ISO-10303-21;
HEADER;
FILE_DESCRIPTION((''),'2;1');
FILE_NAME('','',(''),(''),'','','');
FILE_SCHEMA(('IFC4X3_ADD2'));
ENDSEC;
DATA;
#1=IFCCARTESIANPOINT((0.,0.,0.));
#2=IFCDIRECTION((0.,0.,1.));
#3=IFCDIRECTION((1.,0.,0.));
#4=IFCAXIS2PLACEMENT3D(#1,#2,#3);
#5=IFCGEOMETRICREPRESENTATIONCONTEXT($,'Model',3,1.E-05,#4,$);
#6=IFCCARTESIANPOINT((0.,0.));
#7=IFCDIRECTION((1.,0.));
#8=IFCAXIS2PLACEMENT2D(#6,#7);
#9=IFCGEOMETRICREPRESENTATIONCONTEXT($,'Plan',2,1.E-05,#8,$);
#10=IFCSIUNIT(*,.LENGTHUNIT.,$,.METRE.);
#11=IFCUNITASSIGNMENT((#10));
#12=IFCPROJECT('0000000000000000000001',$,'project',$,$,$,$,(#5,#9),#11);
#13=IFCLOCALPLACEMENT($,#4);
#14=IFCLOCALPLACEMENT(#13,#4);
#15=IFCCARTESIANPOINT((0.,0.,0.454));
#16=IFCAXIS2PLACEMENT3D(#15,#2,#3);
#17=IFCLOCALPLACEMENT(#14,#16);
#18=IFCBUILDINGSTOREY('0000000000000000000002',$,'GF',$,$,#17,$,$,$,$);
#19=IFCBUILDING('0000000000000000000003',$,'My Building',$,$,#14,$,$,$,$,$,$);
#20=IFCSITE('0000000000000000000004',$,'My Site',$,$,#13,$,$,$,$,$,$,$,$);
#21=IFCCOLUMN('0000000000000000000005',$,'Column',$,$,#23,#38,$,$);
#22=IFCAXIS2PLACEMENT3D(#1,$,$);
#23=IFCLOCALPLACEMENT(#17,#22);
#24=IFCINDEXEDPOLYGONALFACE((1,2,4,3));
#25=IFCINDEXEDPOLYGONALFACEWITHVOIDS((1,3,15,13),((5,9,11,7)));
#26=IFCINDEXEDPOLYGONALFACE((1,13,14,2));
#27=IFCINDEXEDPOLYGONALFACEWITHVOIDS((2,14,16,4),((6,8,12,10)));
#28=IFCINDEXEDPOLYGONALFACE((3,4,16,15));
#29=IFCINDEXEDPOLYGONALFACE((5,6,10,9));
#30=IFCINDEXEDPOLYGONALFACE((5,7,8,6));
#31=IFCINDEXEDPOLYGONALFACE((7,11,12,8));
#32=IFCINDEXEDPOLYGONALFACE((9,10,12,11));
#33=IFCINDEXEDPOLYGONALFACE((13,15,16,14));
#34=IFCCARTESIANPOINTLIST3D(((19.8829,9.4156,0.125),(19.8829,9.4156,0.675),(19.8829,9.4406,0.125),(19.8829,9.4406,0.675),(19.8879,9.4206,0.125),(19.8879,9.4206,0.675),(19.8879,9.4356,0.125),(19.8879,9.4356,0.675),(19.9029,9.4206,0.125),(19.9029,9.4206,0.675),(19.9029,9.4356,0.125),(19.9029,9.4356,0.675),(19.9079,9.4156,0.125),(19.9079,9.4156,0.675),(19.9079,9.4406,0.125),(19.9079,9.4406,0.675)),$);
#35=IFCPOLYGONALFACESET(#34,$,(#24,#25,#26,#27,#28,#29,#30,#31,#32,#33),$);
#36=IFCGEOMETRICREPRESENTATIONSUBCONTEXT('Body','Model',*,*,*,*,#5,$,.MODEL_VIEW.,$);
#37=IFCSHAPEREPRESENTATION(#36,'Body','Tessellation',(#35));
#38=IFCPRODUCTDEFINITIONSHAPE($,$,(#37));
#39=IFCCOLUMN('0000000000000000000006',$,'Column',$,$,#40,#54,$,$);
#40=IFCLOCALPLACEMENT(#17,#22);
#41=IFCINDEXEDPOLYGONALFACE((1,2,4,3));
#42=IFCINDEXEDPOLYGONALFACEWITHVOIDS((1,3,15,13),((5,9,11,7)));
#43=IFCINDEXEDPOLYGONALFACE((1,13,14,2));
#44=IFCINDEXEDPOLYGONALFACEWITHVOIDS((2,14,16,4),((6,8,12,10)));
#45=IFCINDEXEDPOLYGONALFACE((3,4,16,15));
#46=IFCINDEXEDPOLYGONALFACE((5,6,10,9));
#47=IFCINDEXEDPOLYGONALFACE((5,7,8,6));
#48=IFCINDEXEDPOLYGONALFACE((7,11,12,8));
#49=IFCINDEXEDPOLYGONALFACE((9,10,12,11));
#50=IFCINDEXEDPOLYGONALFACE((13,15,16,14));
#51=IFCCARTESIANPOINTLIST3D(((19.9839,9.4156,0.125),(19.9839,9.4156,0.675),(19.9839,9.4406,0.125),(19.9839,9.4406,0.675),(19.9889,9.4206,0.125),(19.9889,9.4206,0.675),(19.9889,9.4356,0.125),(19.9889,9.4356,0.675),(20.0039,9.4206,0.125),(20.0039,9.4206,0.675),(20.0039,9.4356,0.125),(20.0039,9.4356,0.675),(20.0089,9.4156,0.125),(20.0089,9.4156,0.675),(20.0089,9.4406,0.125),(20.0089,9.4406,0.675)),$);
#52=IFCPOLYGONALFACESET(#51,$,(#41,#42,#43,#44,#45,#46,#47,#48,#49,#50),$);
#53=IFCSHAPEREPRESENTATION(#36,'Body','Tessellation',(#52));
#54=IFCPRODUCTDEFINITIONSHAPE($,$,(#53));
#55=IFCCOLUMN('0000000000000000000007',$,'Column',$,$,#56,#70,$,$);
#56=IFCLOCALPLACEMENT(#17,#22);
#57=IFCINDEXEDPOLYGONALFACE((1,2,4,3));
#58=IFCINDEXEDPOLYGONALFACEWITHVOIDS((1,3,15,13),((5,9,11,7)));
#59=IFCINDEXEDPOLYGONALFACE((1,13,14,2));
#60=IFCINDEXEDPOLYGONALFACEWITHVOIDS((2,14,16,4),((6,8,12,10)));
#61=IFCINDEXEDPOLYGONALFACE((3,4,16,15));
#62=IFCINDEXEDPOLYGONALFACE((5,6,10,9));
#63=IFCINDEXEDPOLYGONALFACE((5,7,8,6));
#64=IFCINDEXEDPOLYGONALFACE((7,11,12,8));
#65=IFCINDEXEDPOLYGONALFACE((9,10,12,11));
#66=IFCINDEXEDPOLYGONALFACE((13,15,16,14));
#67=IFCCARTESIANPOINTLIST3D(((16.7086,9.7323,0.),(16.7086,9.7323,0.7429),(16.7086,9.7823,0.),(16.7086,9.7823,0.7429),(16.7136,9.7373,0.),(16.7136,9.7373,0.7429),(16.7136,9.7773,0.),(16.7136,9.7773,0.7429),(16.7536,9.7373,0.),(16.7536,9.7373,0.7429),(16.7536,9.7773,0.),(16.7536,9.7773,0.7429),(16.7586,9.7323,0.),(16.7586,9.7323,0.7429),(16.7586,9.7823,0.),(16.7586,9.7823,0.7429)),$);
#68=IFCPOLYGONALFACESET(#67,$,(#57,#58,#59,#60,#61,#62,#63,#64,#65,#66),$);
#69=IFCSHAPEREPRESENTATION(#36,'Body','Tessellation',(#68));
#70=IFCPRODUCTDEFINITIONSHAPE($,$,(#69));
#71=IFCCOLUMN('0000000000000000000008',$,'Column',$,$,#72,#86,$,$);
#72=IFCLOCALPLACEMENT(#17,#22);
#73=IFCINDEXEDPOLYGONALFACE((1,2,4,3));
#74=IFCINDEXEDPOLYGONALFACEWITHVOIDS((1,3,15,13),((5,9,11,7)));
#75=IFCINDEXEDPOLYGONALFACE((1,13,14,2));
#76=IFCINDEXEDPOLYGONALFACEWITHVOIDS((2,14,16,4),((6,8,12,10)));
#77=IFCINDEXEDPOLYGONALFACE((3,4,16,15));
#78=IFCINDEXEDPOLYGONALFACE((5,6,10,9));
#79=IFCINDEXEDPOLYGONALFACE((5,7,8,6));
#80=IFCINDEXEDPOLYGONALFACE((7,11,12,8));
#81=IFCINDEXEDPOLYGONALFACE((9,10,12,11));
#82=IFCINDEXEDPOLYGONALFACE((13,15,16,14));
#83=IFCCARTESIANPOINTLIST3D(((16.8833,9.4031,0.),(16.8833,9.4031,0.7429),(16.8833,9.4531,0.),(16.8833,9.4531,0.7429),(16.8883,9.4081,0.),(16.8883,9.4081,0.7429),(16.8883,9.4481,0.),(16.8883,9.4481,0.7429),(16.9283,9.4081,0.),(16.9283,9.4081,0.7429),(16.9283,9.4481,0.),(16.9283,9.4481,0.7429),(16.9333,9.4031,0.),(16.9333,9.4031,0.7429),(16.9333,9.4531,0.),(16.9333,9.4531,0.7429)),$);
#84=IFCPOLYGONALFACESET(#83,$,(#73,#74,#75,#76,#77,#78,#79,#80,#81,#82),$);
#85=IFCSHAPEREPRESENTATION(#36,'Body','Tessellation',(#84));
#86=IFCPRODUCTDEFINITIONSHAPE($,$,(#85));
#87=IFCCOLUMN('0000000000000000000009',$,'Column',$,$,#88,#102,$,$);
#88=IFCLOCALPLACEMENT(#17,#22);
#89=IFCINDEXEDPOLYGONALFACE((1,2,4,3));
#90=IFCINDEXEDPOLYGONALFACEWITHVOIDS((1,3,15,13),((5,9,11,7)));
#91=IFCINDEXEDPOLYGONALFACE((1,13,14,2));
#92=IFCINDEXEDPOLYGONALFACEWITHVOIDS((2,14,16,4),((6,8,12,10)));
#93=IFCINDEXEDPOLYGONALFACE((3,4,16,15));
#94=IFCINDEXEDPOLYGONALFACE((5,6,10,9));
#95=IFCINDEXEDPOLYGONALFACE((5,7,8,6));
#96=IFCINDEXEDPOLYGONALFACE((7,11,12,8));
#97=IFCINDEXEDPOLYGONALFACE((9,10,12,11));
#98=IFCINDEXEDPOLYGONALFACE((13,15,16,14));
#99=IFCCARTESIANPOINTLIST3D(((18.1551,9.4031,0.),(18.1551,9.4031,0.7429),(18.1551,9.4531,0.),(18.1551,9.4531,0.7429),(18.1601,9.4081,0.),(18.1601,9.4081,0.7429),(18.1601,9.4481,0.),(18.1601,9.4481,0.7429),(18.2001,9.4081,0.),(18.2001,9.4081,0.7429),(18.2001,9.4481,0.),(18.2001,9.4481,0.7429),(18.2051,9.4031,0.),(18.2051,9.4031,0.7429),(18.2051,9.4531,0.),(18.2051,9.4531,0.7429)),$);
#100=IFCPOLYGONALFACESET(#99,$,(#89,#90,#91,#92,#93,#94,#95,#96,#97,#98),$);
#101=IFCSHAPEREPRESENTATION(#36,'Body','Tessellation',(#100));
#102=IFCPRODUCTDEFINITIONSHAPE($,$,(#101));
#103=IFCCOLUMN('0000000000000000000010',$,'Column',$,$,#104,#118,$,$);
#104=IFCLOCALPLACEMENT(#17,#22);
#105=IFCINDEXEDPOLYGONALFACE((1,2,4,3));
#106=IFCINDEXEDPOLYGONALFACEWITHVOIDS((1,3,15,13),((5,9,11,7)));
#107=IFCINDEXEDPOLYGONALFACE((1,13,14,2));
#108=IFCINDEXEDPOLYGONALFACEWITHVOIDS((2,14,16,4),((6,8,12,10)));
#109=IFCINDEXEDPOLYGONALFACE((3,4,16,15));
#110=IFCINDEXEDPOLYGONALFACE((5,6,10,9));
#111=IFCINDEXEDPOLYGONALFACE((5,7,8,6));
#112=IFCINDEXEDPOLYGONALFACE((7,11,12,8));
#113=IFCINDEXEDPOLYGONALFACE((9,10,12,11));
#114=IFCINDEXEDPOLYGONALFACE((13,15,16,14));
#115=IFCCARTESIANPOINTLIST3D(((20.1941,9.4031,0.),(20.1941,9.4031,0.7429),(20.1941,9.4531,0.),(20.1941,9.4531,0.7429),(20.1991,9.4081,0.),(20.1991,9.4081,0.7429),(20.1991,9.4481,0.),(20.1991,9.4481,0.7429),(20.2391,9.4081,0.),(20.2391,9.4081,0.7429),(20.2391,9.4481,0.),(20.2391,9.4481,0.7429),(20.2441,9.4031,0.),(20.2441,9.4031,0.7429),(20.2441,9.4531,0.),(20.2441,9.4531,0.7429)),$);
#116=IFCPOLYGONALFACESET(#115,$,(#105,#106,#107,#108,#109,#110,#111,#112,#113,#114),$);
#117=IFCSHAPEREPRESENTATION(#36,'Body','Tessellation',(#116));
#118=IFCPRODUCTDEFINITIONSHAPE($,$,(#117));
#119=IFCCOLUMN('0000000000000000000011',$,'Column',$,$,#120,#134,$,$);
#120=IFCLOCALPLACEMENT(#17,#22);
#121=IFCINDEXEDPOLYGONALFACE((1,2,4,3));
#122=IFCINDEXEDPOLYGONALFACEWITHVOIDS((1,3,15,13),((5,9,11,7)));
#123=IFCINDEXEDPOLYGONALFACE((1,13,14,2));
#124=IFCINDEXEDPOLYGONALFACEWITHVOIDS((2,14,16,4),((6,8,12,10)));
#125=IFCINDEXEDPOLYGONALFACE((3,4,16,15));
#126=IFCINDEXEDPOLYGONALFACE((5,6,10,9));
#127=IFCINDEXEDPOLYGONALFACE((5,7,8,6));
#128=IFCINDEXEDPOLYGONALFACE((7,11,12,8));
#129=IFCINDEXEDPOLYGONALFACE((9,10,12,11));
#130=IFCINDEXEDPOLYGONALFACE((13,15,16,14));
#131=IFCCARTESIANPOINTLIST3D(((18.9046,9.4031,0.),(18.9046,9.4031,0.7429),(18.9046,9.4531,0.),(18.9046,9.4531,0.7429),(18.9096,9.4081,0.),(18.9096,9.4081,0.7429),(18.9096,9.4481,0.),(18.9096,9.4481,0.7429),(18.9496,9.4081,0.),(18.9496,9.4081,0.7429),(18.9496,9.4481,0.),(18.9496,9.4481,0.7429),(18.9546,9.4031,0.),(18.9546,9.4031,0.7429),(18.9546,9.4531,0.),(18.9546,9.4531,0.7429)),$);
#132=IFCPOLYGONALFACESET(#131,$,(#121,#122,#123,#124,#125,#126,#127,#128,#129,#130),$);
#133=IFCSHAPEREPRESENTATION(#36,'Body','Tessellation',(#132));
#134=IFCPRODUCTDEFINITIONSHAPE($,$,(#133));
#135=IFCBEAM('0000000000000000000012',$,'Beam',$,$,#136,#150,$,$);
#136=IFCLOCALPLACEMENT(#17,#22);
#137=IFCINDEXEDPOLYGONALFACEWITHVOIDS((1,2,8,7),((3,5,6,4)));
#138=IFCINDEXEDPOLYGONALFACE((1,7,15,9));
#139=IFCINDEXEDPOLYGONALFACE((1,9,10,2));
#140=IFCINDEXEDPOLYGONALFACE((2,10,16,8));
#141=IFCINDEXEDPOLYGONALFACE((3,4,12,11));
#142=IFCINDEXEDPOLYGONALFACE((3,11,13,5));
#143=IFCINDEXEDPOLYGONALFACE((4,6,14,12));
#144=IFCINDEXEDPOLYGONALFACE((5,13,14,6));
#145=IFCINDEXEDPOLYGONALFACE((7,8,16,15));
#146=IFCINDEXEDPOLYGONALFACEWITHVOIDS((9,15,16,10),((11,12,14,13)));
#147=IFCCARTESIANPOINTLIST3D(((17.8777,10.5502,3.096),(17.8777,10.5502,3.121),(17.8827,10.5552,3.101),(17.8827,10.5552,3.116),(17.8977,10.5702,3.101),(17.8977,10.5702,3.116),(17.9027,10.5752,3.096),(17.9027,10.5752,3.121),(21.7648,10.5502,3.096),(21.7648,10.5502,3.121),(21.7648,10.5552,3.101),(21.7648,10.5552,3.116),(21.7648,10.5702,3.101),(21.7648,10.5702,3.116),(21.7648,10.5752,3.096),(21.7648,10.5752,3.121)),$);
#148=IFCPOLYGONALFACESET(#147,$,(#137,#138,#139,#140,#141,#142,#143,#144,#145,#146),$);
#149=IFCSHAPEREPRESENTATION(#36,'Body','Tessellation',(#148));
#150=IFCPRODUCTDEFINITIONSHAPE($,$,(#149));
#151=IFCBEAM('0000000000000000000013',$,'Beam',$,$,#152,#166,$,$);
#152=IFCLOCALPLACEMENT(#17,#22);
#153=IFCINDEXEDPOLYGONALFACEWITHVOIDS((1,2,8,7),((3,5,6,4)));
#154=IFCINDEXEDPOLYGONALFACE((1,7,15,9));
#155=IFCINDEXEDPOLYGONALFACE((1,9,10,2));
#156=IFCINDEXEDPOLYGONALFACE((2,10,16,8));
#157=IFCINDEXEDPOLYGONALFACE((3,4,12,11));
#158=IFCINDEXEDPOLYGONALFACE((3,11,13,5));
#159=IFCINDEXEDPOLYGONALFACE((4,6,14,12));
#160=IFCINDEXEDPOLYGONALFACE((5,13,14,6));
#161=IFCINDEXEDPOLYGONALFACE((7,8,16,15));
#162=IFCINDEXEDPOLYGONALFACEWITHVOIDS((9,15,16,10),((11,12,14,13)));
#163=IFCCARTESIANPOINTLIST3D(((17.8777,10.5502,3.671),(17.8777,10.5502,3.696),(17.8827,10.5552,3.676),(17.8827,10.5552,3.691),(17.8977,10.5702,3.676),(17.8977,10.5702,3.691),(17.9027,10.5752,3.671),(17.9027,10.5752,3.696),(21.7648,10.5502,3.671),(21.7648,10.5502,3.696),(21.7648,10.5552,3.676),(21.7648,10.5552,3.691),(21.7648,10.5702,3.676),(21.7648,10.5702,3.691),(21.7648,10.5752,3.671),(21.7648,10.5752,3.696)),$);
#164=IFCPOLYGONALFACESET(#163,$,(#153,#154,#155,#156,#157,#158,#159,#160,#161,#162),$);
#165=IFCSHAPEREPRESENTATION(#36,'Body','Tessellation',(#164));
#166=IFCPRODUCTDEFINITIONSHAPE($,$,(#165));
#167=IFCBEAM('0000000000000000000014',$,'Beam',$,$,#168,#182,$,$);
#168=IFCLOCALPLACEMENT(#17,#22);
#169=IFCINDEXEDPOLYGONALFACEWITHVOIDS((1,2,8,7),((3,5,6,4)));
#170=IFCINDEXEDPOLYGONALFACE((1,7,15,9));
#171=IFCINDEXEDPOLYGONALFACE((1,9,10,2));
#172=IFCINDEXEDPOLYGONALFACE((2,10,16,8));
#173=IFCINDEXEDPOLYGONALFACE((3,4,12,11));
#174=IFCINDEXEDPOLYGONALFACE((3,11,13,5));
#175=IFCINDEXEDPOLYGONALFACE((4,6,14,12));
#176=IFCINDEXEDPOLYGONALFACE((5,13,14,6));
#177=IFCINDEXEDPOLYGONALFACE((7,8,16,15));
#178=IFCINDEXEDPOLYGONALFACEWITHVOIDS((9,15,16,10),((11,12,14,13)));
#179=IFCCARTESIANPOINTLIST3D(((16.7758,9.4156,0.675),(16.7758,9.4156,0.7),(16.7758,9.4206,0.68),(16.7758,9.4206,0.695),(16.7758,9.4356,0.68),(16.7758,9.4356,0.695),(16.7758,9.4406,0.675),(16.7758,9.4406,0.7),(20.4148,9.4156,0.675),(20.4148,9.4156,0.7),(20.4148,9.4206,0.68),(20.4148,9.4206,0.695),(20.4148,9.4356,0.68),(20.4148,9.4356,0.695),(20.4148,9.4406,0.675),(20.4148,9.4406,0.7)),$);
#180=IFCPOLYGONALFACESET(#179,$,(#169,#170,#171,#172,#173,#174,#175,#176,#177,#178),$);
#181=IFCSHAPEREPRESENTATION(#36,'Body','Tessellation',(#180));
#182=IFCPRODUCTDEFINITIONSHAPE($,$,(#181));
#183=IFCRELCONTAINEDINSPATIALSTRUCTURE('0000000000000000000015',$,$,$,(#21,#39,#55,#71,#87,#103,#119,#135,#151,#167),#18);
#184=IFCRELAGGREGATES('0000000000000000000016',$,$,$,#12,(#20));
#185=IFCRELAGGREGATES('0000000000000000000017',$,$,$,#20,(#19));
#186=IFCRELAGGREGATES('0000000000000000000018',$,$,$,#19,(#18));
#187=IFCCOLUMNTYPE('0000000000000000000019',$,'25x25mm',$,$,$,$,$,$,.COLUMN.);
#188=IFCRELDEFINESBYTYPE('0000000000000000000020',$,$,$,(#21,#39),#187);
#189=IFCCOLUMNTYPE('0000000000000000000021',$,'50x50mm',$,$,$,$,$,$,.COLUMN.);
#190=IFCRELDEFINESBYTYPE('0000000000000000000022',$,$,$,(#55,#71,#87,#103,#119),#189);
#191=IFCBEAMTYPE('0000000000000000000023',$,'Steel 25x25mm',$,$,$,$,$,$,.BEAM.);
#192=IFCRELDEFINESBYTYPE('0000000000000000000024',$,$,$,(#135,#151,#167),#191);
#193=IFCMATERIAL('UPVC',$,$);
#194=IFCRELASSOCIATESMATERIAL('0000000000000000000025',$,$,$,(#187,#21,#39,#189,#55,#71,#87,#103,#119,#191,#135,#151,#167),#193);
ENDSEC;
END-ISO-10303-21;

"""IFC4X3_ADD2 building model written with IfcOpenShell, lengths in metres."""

from ifc_helpers import new_model, si_unit, frame, origin_with_axes, origin_2d_with_axis, place, context, subcontext, project, spatial, hollow_rectangle, extrude, clip, halfspace, material, material_profile, profile_set, profile_usage, type_object, element, save


model = new_model("IFC4X3_ADD2")

# Units and contexts
model_context = context("Model", 3, precision=1e-05, world=origin_with_axes())
plan_context = context("Plan", 2, precision=1e-05, world=origin_2d_with_axis())
body_context = subcontext(model_context, "Body", "Model", "MODEL_VIEW")
ifc_project = project(units=[si_unit("LENGTHUNIT", "METRE")], contexts=[model_context, plan_context])

# Site, building, storey
site_placement = place(None, origin_with_axes())
site = spatial("IfcSite", under=ifc_project, at=site_placement, Name="My Site")
building_placement = place(site_placement, origin_with_axes())
building = spatial("IfcBuilding", under=site, at=building_placement, Name="My Building")
storey_placement = place(building_placement, frame((0.0, 0.0, 0.454), z_axis=(0.0, 0.0, 1.0), x_axis=(1.0, 0.0, 0.0)))
storey = spatial("IfcBuildingStorey", under=building, at=storey_placement, Name="GF")

# Columns
ifc_material_1 = material(Name="UPVC")
ifc_material_profile_1 = material_profile(ifc_material_1, hollow_rectangle(XDim=0.025, YDim=0.025, WallThickness=0.005))
ifc_profile_set_1 = profile_set([ifc_material_profile_1])
column_type_1 = type_object("IfcColumnType", Name="25x25mm", PredefinedType="COLUMN", material=ifc_profile_set_1)
ifc_profile_usage_1 = profile_usage(ifc_profile_set_1)
column_1_placement = place(storey_placement, frame((19.8954, 9.4281, 0.125), z_axis=(0.0, 0.0, 1.0), x_axis=(0.0, -1.0, 0.0)))
element("IfcColumn", 1, at=column_1_placement, inside=storey, type_object=column_type_1, material=ifc_profile_usage_1, Name="Column", context=body_context, shape_type="SweptSolid", body=[
    extrude(hollow_rectangle(XDim=0.025, YDim=0.025, WallThickness=0.005), origin_with_axes(), (0.0, 0.0, 1.0), 0.55),
])
ifc_profile_usage_2 = profile_usage(ifc_profile_set_1)
column_2_placement = place(storey_placement, frame((19.9964, 9.4281, 0.125), z_axis=(0.0, 0.0, 1.0), x_axis=(0.0, -1.0, 0.0)))
element("IfcColumn", 2, at=column_2_placement, inside=storey, type_object=column_type_1, material=ifc_profile_usage_2, Name="Column", context=body_context, shape_type="SweptSolid", body=[
    extrude(hollow_rectangle(XDim=0.025, YDim=0.025, WallThickness=0.005), origin_with_axes(), (0.0, 0.0, 1.0), 0.55),
])
ifc_material_profile_2 = material_profile(ifc_material_1, hollow_rectangle(XDim=0.05, YDim=0.05, WallThickness=0.005))
ifc_profile_set_2 = profile_set([ifc_material_profile_2])
ifc_profile_usage_3 = profile_usage(ifc_profile_set_2)
column_type_2 = type_object("IfcColumnType", Name="50x50mm", PredefinedType="COLUMN", material=ifc_profile_set_2)
column_3_placement = place(storey_placement, frame((16.7336, 9.7573, 0.0), z_axis=(0.0, 0.0, 1.0), x_axis=(0.0, -1.0, 0.0)))
element("IfcColumn", 3, at=column_3_placement, inside=storey, type_object=column_type_2, material=ifc_profile_usage_3, Name="Column", context=body_context, shape_type="SweptSolid", body=[
    extrude(hollow_rectangle(XDim=0.05, YDim=0.05, WallThickness=0.005), origin_with_axes(), (0.0, 0.0, 1.0), 0.7429),
])
ifc_profile_usage_4 = profile_usage(ifc_profile_set_2)
column_4_placement = place(storey_placement, frame((16.9083, 9.4281, 0.0), z_axis=(0.0, 0.0, 1.0), x_axis=(1.0, 0.0, 0.0)))
element("IfcColumn", 4, at=column_4_placement, inside=storey, type_object=column_type_2, material=ifc_profile_usage_4, Name="Column", context=body_context, shape_type="SweptSolid", body=[
    extrude(hollow_rectangle(XDim=0.05, YDim=0.05, WallThickness=0.005), origin_with_axes(), (0.0, 0.0, 1.0), 0.7429),
])
ifc_profile_usage_5 = profile_usage(ifc_profile_set_2)
column_5_placement = place(storey_placement, frame((18.1801, 9.4281, 0.0), z_axis=(0.0, 0.0, 1.0), x_axis=(1.0, 0.0, 0.0)))
element("IfcColumn", 5, at=column_5_placement, inside=storey, type_object=column_type_2, material=ifc_profile_usage_5, Name="Column", context=body_context, shape_type="SweptSolid", body=[
    extrude(hollow_rectangle(XDim=0.05, YDim=0.05, WallThickness=0.005), origin_with_axes(), (0.0, 0.0, 1.0), 0.7429),
])
ifc_profile_usage_6 = profile_usage(ifc_profile_set_2)
column_6_placement = place(storey_placement, frame((20.2191, 9.4281, 0.0), z_axis=(0.0, 0.0, 1.0), x_axis=(1.0, 0.0, 0.0)))
element("IfcColumn", 6, at=column_6_placement, inside=storey, type_object=column_type_2, material=ifc_profile_usage_6, Name="Column", context=body_context, shape_type="SweptSolid", body=[
    extrude(hollow_rectangle(XDim=0.05, YDim=0.05, WallThickness=0.005), origin_with_axes(), (0.0, 0.0, 1.0), 0.7429),
])
ifc_profile_usage_7 = profile_usage(ifc_profile_set_2)
column_7_placement = place(storey_placement, frame((18.9296, 9.4281, 0.0), z_axis=(0.0, 0.0, 1.0), x_axis=(1.0, 0.0, 0.0)))
element("IfcColumn", 7, at=column_7_placement, inside=storey, type_object=column_type_2, material=ifc_profile_usage_7, Name="Column", context=body_context, shape_type="SweptSolid", body=[
    extrude(hollow_rectangle(XDim=0.05, YDim=0.05, WallThickness=0.005), origin_with_axes(), (0.0, 0.0, 1.0), 0.7429),
])

# Beams
ifc_material_profile_3 = material_profile(ifc_material_1, hollow_rectangle(XDim=0.025, YDim=0.025, WallThickness=0.005))
ifc_profile_set_3 = profile_set([ifc_material_profile_3])
ifc_profile_usage_8 = profile_usage(ifc_profile_set_3)
beam_type_1 = type_object("IfcBeamType", Name="Steel 25x25mm", PredefinedType="BEAM", material=ifc_profile_set_3)
beam_1_placement = place(storey_placement, frame((17.8777, 10.5627, 3.1085), z_axis=(1.0, 0.0, 0.0), x_axis=(0.0, 1.0, 0.0)))
element("IfcBeam", 8, at=beam_1_placement, inside=storey, type_object=beam_type_1, material=ifc_profile_usage_8, Name="Beam", context=body_context, shape_type="Clipping", body=[
    clip(extrude(hollow_rectangle(XDim=0.025, YDim=0.025, WallThickness=0.005), origin_with_axes(), (0.0, 0.0, 1.0), 3.8871), halfspace(frame((-0.0125, -3.5625, 0.0), z_axis=(0.707134, 0.0, -0.70708), x_axis=(0.0, -1.0, 0.0)), False)),
])
ifc_profile_usage_9 = profile_usage(ifc_profile_set_3)
beam_2_placement = place(storey_placement, frame((17.8777, 10.5627, 3.6835), z_axis=(1.0, 0.0, 0.0), x_axis=(0.0, 1.0, 0.0)))
element("IfcBeam", 9, at=beam_2_placement, inside=storey, type_object=beam_type_1, material=ifc_profile_usage_9, Name="Beam", context=body_context, shape_type="Clipping", body=[
    clip(extrude(hollow_rectangle(XDim=0.025, YDim=0.025, WallThickness=0.005), origin_with_axes(), (0.0, 0.0, 1.0), 3.8871), halfspace(frame((-0.0125, -4.1375, 0.0), z_axis=(0.707134, 0.0, -0.70708), x_axis=(0.0, -1.0, 0.0)), False)),
])
ifc_profile_usage_10 = profile_usage(ifc_profile_set_3)
beam_3_placement = place(storey_placement, frame((16.7758, 9.4281, 0.6875), z_axis=(1.0, 0.0, 0.0), x_axis=(0.0, 1.0, 0.0)))
element("IfcBeam", 10, at=beam_3_placement, inside=storey, type_object=beam_type_1, material=ifc_profile_usage_10, Name="Beam", context=body_context, shape_type="SweptSolid", body=[
    extrude(hollow_rectangle(XDim=0.025, YDim=0.025, WallThickness=0.005), origin_with_axes(), (0.0, 0.0, 1.0), 3.6389),
])

save(model, "model.ifc")
